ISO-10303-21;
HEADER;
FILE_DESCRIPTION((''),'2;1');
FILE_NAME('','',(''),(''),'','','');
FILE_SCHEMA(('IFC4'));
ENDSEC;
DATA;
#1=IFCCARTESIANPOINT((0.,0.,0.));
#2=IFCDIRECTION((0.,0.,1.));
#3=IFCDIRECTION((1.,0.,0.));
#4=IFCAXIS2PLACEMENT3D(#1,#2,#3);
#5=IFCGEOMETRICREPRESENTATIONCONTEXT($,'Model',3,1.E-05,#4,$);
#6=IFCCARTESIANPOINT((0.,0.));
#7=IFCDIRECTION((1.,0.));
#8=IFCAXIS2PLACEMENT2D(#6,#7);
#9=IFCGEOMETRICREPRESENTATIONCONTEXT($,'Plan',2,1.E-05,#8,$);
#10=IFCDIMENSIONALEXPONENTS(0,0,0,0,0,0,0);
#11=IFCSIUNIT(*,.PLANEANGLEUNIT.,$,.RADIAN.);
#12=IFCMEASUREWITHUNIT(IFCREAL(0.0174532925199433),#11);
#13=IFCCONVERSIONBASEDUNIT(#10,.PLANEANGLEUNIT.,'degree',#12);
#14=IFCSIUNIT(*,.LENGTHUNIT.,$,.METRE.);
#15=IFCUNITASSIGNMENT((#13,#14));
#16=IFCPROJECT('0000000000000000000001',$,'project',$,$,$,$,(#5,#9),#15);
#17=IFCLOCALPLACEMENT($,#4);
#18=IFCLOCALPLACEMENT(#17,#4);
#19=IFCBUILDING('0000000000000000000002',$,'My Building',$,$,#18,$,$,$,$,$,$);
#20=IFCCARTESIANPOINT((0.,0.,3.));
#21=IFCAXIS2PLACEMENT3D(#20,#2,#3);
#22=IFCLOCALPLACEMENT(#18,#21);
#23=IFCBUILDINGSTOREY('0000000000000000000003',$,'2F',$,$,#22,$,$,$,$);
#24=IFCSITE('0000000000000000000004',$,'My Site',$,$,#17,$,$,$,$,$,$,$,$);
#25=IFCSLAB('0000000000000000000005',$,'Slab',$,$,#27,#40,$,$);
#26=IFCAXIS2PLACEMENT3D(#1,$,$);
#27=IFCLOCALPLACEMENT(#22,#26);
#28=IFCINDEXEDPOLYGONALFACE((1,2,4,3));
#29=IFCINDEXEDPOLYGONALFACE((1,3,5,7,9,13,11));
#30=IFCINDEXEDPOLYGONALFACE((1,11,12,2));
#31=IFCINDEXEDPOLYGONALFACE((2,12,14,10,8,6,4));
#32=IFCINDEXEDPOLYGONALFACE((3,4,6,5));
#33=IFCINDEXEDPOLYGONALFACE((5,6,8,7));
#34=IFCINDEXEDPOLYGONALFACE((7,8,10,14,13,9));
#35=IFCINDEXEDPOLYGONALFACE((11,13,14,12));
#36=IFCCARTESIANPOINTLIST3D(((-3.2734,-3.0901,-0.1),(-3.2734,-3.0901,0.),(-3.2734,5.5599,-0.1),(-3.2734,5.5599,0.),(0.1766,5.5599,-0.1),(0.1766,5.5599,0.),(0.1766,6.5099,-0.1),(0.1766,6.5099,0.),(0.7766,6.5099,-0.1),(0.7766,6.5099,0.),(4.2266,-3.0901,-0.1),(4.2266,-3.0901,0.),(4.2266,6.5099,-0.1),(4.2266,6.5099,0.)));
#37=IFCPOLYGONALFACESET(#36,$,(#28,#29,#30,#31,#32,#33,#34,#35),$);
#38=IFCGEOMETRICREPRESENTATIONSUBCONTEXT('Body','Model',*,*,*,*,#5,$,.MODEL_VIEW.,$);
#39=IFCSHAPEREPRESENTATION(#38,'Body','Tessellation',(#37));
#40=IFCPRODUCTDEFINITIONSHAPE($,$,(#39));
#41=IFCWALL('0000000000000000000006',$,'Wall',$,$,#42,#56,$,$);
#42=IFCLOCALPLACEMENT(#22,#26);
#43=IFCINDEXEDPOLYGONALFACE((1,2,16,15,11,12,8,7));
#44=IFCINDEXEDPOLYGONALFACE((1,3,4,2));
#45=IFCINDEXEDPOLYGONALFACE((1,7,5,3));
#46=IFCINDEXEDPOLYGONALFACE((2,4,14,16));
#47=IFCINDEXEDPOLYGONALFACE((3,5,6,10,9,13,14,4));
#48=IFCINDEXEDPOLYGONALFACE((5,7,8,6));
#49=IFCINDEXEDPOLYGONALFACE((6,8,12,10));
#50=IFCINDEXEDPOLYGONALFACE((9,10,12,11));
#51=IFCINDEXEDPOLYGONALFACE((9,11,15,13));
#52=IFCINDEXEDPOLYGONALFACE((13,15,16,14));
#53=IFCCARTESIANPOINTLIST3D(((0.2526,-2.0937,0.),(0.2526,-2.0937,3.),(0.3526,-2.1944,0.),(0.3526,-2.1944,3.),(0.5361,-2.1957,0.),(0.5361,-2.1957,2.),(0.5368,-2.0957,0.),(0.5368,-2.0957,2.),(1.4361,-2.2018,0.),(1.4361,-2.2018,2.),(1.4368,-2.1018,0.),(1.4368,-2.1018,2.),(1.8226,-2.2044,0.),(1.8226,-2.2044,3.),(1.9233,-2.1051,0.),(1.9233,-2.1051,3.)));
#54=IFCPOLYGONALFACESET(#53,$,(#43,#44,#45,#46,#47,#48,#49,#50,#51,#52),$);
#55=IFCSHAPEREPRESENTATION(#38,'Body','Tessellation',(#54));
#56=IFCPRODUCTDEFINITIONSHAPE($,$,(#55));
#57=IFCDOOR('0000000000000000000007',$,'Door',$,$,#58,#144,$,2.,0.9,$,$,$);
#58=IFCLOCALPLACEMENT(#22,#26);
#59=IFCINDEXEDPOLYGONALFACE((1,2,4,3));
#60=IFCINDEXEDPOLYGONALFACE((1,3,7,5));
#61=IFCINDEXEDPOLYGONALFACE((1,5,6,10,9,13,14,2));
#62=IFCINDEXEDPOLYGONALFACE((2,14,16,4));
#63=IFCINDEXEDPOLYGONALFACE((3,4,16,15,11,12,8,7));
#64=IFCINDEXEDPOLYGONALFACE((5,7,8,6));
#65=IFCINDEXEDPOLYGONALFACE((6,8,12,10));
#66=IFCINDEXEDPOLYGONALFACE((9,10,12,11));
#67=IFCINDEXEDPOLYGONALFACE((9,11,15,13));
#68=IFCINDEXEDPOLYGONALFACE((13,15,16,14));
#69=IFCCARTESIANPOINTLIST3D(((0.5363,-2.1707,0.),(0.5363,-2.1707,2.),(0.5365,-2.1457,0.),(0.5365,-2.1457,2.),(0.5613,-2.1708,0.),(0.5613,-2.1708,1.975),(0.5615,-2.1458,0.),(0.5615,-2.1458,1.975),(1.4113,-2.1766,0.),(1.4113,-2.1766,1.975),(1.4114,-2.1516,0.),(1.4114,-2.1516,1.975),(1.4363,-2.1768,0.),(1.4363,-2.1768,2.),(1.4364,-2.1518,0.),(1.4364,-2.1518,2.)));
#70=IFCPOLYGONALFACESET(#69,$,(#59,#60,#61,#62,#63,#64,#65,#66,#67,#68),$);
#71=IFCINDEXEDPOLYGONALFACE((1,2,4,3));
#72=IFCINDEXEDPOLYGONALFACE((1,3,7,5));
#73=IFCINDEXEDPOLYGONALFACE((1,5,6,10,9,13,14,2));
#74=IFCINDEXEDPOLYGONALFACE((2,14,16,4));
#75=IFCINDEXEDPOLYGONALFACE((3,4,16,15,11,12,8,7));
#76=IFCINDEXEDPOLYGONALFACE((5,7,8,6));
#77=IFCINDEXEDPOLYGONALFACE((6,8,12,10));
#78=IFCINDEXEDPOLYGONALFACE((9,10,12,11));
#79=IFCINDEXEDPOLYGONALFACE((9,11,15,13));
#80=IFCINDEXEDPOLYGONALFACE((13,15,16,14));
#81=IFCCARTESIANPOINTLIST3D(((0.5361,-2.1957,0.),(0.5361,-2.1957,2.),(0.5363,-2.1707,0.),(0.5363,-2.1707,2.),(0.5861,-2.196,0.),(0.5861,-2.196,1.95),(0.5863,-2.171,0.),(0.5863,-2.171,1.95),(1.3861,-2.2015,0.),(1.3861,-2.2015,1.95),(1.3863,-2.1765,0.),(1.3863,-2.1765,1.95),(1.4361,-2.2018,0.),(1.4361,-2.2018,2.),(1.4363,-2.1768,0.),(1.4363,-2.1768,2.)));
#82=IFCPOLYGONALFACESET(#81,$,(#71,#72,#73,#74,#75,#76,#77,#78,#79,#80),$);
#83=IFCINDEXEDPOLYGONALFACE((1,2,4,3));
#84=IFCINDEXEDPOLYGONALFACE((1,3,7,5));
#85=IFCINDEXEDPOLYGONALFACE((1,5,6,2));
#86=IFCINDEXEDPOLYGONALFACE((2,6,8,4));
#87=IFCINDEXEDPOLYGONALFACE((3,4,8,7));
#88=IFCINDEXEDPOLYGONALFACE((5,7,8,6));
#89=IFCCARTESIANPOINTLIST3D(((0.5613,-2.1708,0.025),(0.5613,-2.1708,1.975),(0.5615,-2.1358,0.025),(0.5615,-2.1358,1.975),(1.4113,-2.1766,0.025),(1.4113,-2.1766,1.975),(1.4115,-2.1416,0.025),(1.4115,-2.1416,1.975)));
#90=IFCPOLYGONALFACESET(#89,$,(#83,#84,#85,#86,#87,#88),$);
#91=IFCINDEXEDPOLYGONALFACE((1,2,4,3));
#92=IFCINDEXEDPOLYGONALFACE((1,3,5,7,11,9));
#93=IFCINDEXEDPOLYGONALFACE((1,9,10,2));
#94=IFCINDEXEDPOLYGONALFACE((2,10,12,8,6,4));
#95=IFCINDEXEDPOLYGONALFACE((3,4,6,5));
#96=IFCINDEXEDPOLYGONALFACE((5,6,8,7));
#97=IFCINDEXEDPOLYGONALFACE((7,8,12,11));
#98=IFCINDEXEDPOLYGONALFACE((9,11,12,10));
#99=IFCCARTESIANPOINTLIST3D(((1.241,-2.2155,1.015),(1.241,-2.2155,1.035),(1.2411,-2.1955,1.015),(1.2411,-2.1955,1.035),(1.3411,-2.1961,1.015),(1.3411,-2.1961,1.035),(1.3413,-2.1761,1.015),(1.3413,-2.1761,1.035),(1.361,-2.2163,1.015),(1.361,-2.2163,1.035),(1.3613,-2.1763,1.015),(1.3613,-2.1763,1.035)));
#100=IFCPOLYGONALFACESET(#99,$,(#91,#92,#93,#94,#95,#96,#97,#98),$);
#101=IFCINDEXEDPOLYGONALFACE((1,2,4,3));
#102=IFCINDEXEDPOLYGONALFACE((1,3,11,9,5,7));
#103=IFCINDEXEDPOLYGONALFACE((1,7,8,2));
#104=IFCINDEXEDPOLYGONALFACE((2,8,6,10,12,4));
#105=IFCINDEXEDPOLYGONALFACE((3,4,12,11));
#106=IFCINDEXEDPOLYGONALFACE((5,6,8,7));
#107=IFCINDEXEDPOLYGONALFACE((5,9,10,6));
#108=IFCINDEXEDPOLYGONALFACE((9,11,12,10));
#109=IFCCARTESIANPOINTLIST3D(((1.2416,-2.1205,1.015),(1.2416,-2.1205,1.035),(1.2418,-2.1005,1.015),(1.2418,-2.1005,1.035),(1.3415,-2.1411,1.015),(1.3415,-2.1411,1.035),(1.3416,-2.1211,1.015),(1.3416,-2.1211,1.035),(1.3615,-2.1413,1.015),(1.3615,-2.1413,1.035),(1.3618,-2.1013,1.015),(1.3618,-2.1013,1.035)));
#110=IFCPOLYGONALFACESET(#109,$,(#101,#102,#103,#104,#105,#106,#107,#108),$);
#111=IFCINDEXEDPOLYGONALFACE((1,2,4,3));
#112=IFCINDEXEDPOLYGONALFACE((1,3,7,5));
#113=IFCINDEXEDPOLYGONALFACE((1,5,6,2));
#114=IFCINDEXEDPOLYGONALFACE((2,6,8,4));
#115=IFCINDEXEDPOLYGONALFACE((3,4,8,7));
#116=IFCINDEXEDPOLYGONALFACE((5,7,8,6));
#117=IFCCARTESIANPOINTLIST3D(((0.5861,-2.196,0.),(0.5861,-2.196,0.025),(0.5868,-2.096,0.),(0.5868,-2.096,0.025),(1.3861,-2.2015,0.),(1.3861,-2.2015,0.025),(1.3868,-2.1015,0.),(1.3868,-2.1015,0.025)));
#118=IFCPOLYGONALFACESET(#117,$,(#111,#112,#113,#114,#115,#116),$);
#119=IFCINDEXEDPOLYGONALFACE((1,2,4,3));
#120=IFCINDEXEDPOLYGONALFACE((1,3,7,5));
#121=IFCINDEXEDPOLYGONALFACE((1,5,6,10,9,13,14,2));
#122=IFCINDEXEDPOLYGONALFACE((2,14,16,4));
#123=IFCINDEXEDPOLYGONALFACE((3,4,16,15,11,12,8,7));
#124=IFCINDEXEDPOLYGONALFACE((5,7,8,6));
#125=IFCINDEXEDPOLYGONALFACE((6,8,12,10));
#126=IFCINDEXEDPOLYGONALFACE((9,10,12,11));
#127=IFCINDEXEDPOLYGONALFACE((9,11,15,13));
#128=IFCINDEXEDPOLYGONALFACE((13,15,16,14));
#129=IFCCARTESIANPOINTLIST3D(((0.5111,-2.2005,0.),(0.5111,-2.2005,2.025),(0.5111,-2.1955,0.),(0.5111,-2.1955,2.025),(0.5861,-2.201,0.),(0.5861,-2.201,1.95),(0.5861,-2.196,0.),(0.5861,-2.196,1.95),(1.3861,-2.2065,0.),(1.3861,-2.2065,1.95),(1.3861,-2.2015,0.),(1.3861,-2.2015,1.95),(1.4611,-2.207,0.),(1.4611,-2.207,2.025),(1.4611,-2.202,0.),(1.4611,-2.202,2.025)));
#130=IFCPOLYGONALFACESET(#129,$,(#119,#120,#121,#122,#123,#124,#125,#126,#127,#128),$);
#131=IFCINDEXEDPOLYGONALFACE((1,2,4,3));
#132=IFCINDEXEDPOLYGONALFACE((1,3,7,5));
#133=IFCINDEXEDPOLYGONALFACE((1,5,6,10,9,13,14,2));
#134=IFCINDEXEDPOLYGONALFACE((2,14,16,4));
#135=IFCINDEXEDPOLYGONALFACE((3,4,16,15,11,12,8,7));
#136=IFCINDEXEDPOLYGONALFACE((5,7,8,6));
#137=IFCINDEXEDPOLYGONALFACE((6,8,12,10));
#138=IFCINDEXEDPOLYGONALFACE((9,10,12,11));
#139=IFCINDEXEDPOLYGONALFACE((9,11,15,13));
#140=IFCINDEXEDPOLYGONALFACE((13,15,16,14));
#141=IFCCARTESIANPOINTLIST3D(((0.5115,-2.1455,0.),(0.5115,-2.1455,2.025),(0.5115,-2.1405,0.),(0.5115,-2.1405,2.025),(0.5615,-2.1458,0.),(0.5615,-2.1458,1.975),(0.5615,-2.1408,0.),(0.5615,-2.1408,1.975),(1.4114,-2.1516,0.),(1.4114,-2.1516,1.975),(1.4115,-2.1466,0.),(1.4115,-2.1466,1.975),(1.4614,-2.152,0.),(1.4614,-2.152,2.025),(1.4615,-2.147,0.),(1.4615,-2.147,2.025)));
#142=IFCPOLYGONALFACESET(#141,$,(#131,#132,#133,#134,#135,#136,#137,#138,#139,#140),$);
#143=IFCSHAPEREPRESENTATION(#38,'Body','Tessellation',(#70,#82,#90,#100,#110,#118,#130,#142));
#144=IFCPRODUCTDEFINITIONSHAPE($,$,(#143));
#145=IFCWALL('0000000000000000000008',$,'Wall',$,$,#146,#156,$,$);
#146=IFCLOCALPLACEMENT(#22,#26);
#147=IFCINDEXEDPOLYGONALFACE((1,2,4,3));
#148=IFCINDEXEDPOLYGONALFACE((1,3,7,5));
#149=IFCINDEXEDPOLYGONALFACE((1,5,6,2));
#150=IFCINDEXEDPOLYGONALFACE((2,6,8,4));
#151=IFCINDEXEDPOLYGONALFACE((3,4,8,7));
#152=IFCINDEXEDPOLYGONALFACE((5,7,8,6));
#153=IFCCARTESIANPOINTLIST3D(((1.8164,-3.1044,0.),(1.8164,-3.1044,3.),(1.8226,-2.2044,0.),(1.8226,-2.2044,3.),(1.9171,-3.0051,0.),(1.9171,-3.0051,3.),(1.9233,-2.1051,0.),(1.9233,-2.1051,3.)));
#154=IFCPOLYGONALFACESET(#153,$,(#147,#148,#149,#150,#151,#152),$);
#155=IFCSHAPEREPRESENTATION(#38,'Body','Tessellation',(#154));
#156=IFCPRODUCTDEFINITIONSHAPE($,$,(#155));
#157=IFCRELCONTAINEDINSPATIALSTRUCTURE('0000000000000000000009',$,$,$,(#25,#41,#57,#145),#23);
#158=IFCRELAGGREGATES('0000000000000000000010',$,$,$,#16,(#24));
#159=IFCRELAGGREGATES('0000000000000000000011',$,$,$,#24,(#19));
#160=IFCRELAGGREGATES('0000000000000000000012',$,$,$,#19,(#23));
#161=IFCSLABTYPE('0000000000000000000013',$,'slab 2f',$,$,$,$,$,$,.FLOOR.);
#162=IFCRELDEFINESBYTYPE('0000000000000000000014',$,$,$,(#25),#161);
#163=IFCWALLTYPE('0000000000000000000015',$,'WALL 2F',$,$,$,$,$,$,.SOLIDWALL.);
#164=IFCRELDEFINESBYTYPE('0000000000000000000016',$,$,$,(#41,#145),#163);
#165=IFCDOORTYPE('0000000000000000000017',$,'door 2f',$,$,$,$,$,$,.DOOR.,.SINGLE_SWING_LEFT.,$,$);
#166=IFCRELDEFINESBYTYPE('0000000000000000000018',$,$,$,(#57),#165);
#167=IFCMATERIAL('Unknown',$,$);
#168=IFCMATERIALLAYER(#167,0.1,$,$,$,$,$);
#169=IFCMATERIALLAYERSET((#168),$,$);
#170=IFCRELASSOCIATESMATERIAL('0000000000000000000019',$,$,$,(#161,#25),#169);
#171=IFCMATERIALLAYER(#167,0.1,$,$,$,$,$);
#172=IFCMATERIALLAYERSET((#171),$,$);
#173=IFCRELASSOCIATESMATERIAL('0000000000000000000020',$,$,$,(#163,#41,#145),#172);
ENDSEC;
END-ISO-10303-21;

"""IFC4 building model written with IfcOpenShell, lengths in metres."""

from ifc_helpers import new_model, entity, si_unit, converted_unit, frame, origin_with_axes, origin_2d_with_axis, place, context, subcontext, project, spatial, line, indexed_curve, outline, extrude, shape, source, transform, mapped, material, layer, layer_set, layer_usage, type_object, type_shapes, element, fill, save


model = new_model("IFC4")

# Units and contexts
model_context = context("Model", 3, precision=1e-05, world=origin_with_axes())
plan_context = context("Plan", 2, precision=1e-05, world=origin_2d_with_axis())
body_context_1 = subcontext(model_context, "Body", "Model", "MODEL_VIEW")
body_context_2 = subcontext(plan_context, "Body", "Plan", "PLAN_VIEW")
ifc_project = project(units=[converted_unit("PLANEANGLEUNIT", "degree", entity("IfcReal", 0.0174532925199433), si_unit("PLANEANGLEUNIT", "RADIAN"), dimensions=[0, 0, 0, 0, 0, 0, 0]), si_unit("LENGTHUNIT", "METRE")], contexts=[model_context, plan_context])

# Site, building, storey
site_placement = place(None, origin_with_axes())
site = spatial("IfcSite", under=ifc_project, at=site_placement, Name="My Site")
building_placement = place(site_placement, origin_with_axes())
building = spatial("IfcBuilding", under=site, at=building_placement, Name="My Building")
storey_placement = place(building_placement, frame((0.0, 0.0, 3.0), z_axis=(0.0, 0.0, 1.0), x_axis=(1.0, 0.0, 0.0)))
storey = spatial("IfcBuildingStorey", under=building, at=storey_placement, Name="2F")

# Slab
ifc_material = material(Name="Unknown")
ifc_layer_1 = layer(ifc_material, 0.1)
ifc_layer_set_1 = layer_set([ifc_layer_1])
ifc_layer_usage_1 = layer_usage(ifc_layer_set_1, "AXIS3", "POSITIVE", -0.1)
slab_type = type_object("IfcSlabType", Name="slab 2f", PredefinedType="FLOOR", material=ifc_layer_set_1)
slab_placement = place(storey_placement, frame((0.7766, 6.5099, 0.0), z_axis=(0.0, 0.0, 1.0), x_axis=(1.0, 0.0, 0.0)))
element("IfcSlab", 1, at=slab_placement, inside=storey, type_object=slab_type, material=ifc_layer_usage_1, Name="Slab", context=body_context_1, shape_type="SweptSolid", body=[
    extrude(outline(indexed_curve([(0.0, 0.0), (-0.6, 0.0), (-0.6, -0.95), (-4.05, -0.95), (-4.05, -9.6), (3.45, -9.6), (3.45, 0.0), (0.0, 0.0)])), frame((0.0, 0.0, -0.1), z_axis=(0.0, 0.0, 1.0), x_axis=(1.0, 0.0, 0.0)), (0.0, 0.0, 1.0), 0.1),
])

# Wall, opening, door
ifc_layer_2 = layer(ifc_material, 0.1)
ifc_layer_set_2 = layer_set([ifc_layer_2])
ifc_layer_usage_2 = layer_usage(ifc_layer_set_2, "AXIS2", "POSITIVE", 0.0)
wall_type = type_object("IfcWallType", Name="WALL 2F", PredefinedType="SOLIDWALL", material=ifc_layer_set_2)
wall_1_placement = place(storey_placement, frame((0.2526, -2.1937, 0.0), z_axis=(0.0, 0.0, 1.0), x_axis=(0.999977, -0.006814, 0.0)))
wall_1 = element("IfcWall", 2, at=wall_1_placement, inside=storey, type_object=wall_type, material=ifc_layer_usage_2, Name="Wall", context=body_context_1, shape_type="SweptSolid", body=[
    extrude(outline(indexed_curve([(0.1, 0.0), (-0.0007, 0.1), (1.67, 0.1), (1.57, 0.0)], segments=[line(1, 2, 3, 4, 1)])), origin_with_axes(), (0.0, 0.0, 1.0), 3.0),
])
shared_shape_1 = source(origin_with_axes(), body_context_1, "Body", "SweptSolid", [
    extrude(outline(indexed_curve([(0.0, 0.0), (0.9, 0.0), (0.9, 2.0), (0.0, 2.0)], segments=[line(1, 2, 3, 4, 1)])), frame((0.0, -0.6, 0.0), z_axis=(0.0, -1.0, 0.0), x_axis=(1.0, 0.0, 0.0)), (0.0, 0.0, -1.0), 1.2),
])
opening_1_placement = place(wall_1_placement, frame((0.2835, 0.0, 0.0), z_axis=(0.0, 0.0, 1.0), x_axis=(1.0, 0.0, 0.0)))
opening_1 = element("IfcOpeningElement", 3, at=opening_1_placement, cuts=wall_1, PredefinedType="OPENING", context=body_context_1, shape_type="MappedRepresentation", body=[
    mapped(shared_shape_1, transform((0.0, 0.0, 0.0), x_axis=(1.0, 0.0, 0.0), y_axis=(0.0, 1.0, 0.0), z_axis=(0.0, 0.0, 1.0), scale=1.0)),
])
door_type_1 = type_object("IfcDoorType", Name="door 2f", OperationType="SINGLE_SWING_LEFT", PredefinedType="DOOR")
shared_shape_2 = source(origin_with_axes(), body_context_1, "Body", "SweptSolid", [
    extrude(outline(indexed_curve([(0.0, 0.0), (0.0, 2.0), (0.9, 2.0), (0.9, 0.0), (0.875, 0.0), (0.875, 1.975), (0.025, 1.975), (0.025, 0.0)], segments=[line(1, 2, 3, 4, 5, 6, 7, 8, 1)])), frame((0.0, 0.025, 0.0), z_axis=(0.0, -1.0, 0.0), x_axis=(1.0, 0.0, 0.0)), (0.0, 0.0, -1.0), 0.025),
    extrude(outline(indexed_curve([(0.0, 0.0), (0.0, 2.0), (0.9, 2.0), (0.9, 0.0), (0.85, 0.0), (0.85, 1.95), (0.05, 1.95), (0.05, 0.0)], segments=[line(1, 2, 3, 4, 5, 6, 7, 8, 1)])), frame((0.0, 0.0, 0.0), z_axis=(0.0, -1.0, 0.0), x_axis=(1.0, 0.0, 0.0)), (0.0, 0.0, -1.0), 0.025),
    extrude(outline(indexed_curve([(0.0, 0.0), (0.85, 0.0), (0.85, 0.035), (0.0, 0.035)], segments=[line(1, 2, 3, 4, 1)])), frame((0.025, 0.025, 0.025), z_axis=(0.0, 0.0, 1.0), x_axis=(1.0, 0.0, 0.0)), (0.0, 0.0, 1.0), 1.95),
    extrude(outline(indexed_curve([(0.0, 0.0), (0.0, -0.04), (-0.12, -0.04), (-0.12, -0.02), (-0.02, -0.02), (-0.02, 0.0)], segments=[line(1, 2, 3, 4, 5, 6, 1)])), frame((0.825, 0.025, 1.015), z_axis=(0.0, 0.0, 1.0), x_axis=(1.0, 0.0, 0.0)), (0.0, 0.0, 1.0), 0.02),
    extrude(outline(indexed_curve([(0.0, 0.0), (0.0, 0.04), (-0.12, 0.04), (-0.12, 0.02), (-0.02, 0.02), (-0.02, 0.0)], segments=[line(1, 2, 3, 4, 5, 6, 1)])), frame((0.825, 0.06, 1.015), z_axis=(0.0, 0.0, 1.0), x_axis=(1.0, 0.0, 0.0)), (0.0, 0.0, 1.0), 0.02),
    extrude(outline(indexed_curve([(0.0, 0.0), (0.8, 0.0), (0.8, 0.1), (0.0, 0.1)], segments=[line(1, 2, 3, 4, 1)])), frame((0.05, 0.0, 0.0), z_axis=(0.0, 0.0, 1.0), x_axis=(1.0, 0.0, 0.0)), (0.0, 0.0, 1.0), 0.025),
    extrude(outline(indexed_curve([(0.0, 0.0), (0.0, 2.025), (0.95, 2.025), (0.95, 0.0), (0.875, 0.0), (0.875, 1.95), (0.075, 1.95), (0.075, 0.0)], segments=[line(1, 2, 3, 4, 5, 6, 7, 8, 1)])), frame((-0.025, -0.005, 0.0), z_axis=(0.0, -1.0, 0.0), x_axis=(1.0, 0.0, 0.0)), (0.0, 0.0, -1.0), 0.005),
    extrude(outline(indexed_curve([(0.0, 0.0), (0.0, 2.025), (0.95, 2.025), (0.95, 0.0), (0.9, 0.0), (0.9, 1.975), (0.05, 1.975), (0.05, 0.0)], segments=[line(1, 2, 3, 4, 5, 6, 7, 8, 1)])), frame((-0.025, 0.05, 0.0), z_axis=(0.0, -1.0, 0.0), x_axis=(1.0, 0.0, 0.0)), (0.0, 0.0, -1.0), 0.005),
])
shared_shape_3 = source(origin_with_axes(), body_context_2, "Body", "Curve2D", [
    entity("IfcIndexedPolyCurve", entity("IfcCartesianPointList2D", [[0.0, 0.0], [0.0, 0.05], [0.025, 0.05], [0.025, 0.025], [0.05, 0.025], [0.05, 0.0]]), [entity("IfcLineIndex", [1, 2, 3, 4, 5, 6, 1])]),
    entity("IfcIndexedPolyCurve", entity("IfcCartesianPointList2D", [[0.9, 0.0], [0.9, 0.05], [0.875, 0.05], [0.875, 0.025], [0.85, 0.025], [0.85, 0.0]]), [entity("IfcLineIndex", [1, 2, 3, 4, 5, 6, 1])]),
    entity("IfcTrimmedCurve", entity("IfcEllipse", entity("IfcAxis2Placement2D", entity("IfcCartesianPoint", [0.06, 0.05]), entity("IfcDirection", [1.0, 0.0])), 0.815, 0.85), [entity("IfcCartesianPoint", [0.875, 0.05])], [entity("IfcCartesianPoint", [0.06, 0.9])], True, "CARTESIAN"),
    entity("IfcIndexedPolyCurve", entity("IfcCartesianPointList2D", [[0.025, 0.05], [0.06, 0.05], [0.06, 0.9], [0.025, 0.9]]), [entity("IfcLineIndex", [1, 2, 3, 4, 1])]),
])
type_shapes(door_type_1, [shared_shape_2, shared_shape_3])
door_1_placement = place(opening_1_placement, frame((0.0, 0.0, 0.0), z_axis=(0.0, 0.0, 1.0), x_axis=(1.0, 0.0, 0.0)))
door_1 = element("IfcDoor", 4, at=door_1_placement, inside=storey, type_object=door_type_1, Name="Door", OverallHeight=2.0, OverallWidth=0.9, shapes=[
    shape(body_context_1, "Body", "MappedRepresentation", [mapped(shared_shape_2, transform((0.0, 0.0, 0.0), x_axis=(1.0, 0.0, 0.0), y_axis=(0.0, 1.0, 0.0), z_axis=(0.0, 0.0, 1.0), scale=1.0))]),
    shape(body_context_2, "Body", "MappedRepresentation", [mapped(shared_shape_3, transform((0.0, 0.0, 0.0), x_axis=(1.0, 0.0, 0.0), y_axis=(0.0, 1.0, 0.0), z_axis=(0.0, 0.0, 1.0), scale=1.0))]),
])
fill(opening_1, door_1)

# Wall
ifc_layer_usage_3 = layer_usage(ifc_layer_set_2, "AXIS2", "POSITIVE", 0.0)
wall_2_placement = place(storey_placement, frame((1.8226, -2.2044, 0.0), z_axis=(0.0, 0.0, 1.0), x_axis=(-0.006814, -0.999977, 0.0)))
element("IfcWall", 5, at=wall_2_placement, inside=storey, type_object=wall_type, material=ifc_layer_usage_3, Name="Wall", context=body_context_1, shape_type="SweptSolid", body=[
    extrude(outline(indexed_curve([(0.0, 0.0), (-0.1, 0.1), (0.8, 0.1), (0.9, 0.0)], segments=[line(1, 2, 3, 4, 1)])), origin_with_axes(), (0.0, 0.0, 1.0), 3.0),
])

save(model, "model.ifc")
